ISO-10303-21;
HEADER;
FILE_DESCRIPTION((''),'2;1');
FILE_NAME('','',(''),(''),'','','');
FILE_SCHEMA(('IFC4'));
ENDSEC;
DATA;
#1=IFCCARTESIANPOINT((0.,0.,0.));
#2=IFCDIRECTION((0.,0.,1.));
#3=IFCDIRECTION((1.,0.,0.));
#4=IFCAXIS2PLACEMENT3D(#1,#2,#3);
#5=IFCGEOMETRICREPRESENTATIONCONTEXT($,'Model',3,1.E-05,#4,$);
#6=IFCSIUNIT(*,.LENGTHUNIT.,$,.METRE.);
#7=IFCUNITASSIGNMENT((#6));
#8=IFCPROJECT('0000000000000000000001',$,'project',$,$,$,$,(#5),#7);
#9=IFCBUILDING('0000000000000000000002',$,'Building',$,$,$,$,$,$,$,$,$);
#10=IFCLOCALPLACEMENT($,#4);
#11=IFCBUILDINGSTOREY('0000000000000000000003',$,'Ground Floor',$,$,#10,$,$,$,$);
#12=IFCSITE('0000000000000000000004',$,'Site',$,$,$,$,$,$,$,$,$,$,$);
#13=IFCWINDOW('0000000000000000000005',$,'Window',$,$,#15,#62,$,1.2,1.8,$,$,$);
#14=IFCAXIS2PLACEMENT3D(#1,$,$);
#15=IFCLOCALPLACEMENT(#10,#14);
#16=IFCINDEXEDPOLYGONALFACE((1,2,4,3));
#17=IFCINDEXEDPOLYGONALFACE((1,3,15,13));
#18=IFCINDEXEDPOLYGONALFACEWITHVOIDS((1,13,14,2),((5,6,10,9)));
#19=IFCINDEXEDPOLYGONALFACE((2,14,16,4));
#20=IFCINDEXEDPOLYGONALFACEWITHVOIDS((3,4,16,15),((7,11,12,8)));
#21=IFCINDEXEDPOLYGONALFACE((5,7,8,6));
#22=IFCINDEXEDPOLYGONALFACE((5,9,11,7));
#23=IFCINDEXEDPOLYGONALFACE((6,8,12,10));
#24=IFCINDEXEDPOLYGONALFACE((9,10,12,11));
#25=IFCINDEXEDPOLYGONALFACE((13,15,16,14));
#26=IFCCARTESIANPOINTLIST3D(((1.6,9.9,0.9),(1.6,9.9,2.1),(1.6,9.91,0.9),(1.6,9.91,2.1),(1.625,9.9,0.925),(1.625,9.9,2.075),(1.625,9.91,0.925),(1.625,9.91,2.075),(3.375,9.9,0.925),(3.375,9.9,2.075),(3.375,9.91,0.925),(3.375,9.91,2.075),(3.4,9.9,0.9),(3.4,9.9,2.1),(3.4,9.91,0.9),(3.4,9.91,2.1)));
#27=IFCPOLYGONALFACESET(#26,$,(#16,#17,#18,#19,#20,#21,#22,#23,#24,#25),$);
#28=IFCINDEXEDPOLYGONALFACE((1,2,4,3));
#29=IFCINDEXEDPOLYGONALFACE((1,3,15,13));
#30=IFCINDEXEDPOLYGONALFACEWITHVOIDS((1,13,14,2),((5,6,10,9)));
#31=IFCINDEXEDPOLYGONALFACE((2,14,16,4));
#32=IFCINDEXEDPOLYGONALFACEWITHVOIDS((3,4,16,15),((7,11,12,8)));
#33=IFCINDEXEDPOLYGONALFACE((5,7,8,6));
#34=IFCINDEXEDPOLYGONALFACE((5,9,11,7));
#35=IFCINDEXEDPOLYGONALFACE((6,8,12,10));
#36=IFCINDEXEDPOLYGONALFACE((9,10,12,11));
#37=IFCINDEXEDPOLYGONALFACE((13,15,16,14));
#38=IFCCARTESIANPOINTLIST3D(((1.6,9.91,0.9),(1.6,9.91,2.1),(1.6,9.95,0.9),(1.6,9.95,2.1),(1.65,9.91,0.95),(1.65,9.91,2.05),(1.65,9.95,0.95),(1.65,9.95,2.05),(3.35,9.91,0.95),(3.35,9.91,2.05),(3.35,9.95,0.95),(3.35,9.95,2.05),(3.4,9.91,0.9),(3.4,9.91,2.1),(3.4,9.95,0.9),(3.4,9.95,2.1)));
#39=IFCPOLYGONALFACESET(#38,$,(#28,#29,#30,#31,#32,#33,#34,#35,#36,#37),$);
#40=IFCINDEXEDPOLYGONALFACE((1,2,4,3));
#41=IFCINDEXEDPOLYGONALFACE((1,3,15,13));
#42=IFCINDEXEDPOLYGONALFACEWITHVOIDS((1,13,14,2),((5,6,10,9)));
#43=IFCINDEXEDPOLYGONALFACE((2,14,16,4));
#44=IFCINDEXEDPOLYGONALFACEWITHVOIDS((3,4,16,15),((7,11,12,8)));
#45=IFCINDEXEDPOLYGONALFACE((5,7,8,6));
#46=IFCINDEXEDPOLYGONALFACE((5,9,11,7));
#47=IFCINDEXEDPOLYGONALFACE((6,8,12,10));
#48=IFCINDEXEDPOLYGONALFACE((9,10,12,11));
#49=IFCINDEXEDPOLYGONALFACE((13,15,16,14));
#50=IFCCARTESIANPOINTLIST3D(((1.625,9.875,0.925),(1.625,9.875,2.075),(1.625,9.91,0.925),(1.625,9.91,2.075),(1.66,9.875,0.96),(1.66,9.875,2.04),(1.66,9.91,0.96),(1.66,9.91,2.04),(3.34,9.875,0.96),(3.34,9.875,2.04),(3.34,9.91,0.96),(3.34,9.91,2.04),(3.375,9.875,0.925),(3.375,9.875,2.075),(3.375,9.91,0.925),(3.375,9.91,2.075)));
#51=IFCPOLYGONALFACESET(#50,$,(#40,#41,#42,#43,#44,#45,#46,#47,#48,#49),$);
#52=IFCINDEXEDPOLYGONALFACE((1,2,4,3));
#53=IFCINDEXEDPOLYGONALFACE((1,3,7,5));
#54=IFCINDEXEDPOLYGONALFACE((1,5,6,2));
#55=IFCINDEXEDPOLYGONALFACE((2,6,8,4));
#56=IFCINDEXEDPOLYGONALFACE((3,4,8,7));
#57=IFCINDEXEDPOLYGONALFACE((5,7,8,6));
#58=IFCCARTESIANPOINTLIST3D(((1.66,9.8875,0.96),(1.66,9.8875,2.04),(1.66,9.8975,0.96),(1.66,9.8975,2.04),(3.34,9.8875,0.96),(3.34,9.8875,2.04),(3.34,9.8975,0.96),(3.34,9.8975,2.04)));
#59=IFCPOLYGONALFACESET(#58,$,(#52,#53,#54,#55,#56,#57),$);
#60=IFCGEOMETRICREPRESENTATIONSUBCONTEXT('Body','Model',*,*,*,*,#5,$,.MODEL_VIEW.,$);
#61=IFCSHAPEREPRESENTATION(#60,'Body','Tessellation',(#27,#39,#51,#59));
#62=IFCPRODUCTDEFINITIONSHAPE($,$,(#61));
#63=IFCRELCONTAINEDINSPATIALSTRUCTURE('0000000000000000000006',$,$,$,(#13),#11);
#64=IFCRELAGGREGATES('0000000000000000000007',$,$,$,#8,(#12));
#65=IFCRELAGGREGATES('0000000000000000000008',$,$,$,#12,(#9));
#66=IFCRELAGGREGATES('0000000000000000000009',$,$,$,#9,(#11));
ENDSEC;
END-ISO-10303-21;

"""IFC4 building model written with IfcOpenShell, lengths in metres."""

from ifc_helpers import new_model, si_unit, frame, origin_with_axes, place, context, subcontext, project, spatial, line, indexed_curve, outline, extrude, element, save


model = new_model("IFC4")

# Units and contexts
model_context = context("Model", 3, precision=1e-05, world=origin_with_axes())
body_context = subcontext(model_context, "Body", "Model", "MODEL_VIEW")
ifc_project = project(units=[si_unit("LENGTHUNIT", "METRE")], contexts=[model_context])

# Site, building, storey
site = spatial("IfcSite", under=ifc_project, Name="Site")
building = spatial("IfcBuilding", under=site, Name="Building")
storey_placement = place(None, origin_with_axes())
storey = spatial("IfcBuildingStorey", under=building, at=storey_placement, Name="Ground Floor")

# Window
window_1_placement = place(storey_placement, frame((3.4, 10.0, 0.9), z_axis=(0.0, 0.0, 1.0), x_axis=(-1.0, 0.0, 0.0)))
element("IfcWindow", 1, at=window_1_placement, inside=storey, Name="Window", OverallHeight=1.2, OverallWidth=1.8, context=body_context, shape_type="SweptSolid", body=[
    extrude(outline(indexed_curve([(0.0, 0.0), (1.8, 0.0), (1.8, 1.2), (0.0, 1.2)], segments=[line(1, 2, 3, 4, 1)]), holes=[indexed_curve([(0.025, 0.025), (1.775, 0.025), (1.775, 1.175), (0.025, 1.175)], segments=[line(1, 2, 3, 4, 1)])]), frame((0.0, 0.09, 0.0), z_axis=(0.0, -1.0, 0.0), x_axis=(1.0, 0.0, 0.0)), (0.0, 0.0, -1.0), 0.01),
    extrude(outline(indexed_curve([(0.0, 0.0), (1.8, 0.0), (1.8, 1.2), (0.0, 1.2)], segments=[line(1, 2, 3, 4, 1)]), holes=[indexed_curve([(0.05, 0.05), (1.75, 0.05), (1.75, 1.15), (0.05, 1.15)], segments=[line(1, 2, 3, 4, 1)])]), frame((0.0, 0.05, 0.0), z_axis=(0.0, -1.0, 0.0), x_axis=(1.0, 0.0, 0.0)), (0.0, 0.0, -1.0), 0.04),
    extrude(outline(indexed_curve([(0.0, 0.0), (1.75, 0.0), (1.75, 1.15), (0.0, 1.15)], segments=[line(1, 2, 3, 4, 1)]), holes=[indexed_curve([(0.035, 0.035), (1.715, 0.035), (1.715, 1.115), (0.035, 1.115)], segments=[line(1, 2, 3, 4, 1)])]), frame((0.025, 0.09, 0.025), z_axis=(0.0, -1.0, 0.0), x_axis=(1.0, 0.0, 0.0)), (0.0, 0.0, -1.0), 0.035),
    extrude(outline(indexed_curve([(0.035, 0.035), (1.715, 0.035), (1.715, 1.115), (0.035, 1.115)], segments=[line(1, 2, 3, 4, 1)])), frame((0.025, 0.1025, 0.025), z_axis=(0.0, -1.0, 0.0), x_axis=(1.0, 0.0, 0.0)), (0.0, 0.0, -1.0), 0.01),
])

save(model, "model.ifc")
